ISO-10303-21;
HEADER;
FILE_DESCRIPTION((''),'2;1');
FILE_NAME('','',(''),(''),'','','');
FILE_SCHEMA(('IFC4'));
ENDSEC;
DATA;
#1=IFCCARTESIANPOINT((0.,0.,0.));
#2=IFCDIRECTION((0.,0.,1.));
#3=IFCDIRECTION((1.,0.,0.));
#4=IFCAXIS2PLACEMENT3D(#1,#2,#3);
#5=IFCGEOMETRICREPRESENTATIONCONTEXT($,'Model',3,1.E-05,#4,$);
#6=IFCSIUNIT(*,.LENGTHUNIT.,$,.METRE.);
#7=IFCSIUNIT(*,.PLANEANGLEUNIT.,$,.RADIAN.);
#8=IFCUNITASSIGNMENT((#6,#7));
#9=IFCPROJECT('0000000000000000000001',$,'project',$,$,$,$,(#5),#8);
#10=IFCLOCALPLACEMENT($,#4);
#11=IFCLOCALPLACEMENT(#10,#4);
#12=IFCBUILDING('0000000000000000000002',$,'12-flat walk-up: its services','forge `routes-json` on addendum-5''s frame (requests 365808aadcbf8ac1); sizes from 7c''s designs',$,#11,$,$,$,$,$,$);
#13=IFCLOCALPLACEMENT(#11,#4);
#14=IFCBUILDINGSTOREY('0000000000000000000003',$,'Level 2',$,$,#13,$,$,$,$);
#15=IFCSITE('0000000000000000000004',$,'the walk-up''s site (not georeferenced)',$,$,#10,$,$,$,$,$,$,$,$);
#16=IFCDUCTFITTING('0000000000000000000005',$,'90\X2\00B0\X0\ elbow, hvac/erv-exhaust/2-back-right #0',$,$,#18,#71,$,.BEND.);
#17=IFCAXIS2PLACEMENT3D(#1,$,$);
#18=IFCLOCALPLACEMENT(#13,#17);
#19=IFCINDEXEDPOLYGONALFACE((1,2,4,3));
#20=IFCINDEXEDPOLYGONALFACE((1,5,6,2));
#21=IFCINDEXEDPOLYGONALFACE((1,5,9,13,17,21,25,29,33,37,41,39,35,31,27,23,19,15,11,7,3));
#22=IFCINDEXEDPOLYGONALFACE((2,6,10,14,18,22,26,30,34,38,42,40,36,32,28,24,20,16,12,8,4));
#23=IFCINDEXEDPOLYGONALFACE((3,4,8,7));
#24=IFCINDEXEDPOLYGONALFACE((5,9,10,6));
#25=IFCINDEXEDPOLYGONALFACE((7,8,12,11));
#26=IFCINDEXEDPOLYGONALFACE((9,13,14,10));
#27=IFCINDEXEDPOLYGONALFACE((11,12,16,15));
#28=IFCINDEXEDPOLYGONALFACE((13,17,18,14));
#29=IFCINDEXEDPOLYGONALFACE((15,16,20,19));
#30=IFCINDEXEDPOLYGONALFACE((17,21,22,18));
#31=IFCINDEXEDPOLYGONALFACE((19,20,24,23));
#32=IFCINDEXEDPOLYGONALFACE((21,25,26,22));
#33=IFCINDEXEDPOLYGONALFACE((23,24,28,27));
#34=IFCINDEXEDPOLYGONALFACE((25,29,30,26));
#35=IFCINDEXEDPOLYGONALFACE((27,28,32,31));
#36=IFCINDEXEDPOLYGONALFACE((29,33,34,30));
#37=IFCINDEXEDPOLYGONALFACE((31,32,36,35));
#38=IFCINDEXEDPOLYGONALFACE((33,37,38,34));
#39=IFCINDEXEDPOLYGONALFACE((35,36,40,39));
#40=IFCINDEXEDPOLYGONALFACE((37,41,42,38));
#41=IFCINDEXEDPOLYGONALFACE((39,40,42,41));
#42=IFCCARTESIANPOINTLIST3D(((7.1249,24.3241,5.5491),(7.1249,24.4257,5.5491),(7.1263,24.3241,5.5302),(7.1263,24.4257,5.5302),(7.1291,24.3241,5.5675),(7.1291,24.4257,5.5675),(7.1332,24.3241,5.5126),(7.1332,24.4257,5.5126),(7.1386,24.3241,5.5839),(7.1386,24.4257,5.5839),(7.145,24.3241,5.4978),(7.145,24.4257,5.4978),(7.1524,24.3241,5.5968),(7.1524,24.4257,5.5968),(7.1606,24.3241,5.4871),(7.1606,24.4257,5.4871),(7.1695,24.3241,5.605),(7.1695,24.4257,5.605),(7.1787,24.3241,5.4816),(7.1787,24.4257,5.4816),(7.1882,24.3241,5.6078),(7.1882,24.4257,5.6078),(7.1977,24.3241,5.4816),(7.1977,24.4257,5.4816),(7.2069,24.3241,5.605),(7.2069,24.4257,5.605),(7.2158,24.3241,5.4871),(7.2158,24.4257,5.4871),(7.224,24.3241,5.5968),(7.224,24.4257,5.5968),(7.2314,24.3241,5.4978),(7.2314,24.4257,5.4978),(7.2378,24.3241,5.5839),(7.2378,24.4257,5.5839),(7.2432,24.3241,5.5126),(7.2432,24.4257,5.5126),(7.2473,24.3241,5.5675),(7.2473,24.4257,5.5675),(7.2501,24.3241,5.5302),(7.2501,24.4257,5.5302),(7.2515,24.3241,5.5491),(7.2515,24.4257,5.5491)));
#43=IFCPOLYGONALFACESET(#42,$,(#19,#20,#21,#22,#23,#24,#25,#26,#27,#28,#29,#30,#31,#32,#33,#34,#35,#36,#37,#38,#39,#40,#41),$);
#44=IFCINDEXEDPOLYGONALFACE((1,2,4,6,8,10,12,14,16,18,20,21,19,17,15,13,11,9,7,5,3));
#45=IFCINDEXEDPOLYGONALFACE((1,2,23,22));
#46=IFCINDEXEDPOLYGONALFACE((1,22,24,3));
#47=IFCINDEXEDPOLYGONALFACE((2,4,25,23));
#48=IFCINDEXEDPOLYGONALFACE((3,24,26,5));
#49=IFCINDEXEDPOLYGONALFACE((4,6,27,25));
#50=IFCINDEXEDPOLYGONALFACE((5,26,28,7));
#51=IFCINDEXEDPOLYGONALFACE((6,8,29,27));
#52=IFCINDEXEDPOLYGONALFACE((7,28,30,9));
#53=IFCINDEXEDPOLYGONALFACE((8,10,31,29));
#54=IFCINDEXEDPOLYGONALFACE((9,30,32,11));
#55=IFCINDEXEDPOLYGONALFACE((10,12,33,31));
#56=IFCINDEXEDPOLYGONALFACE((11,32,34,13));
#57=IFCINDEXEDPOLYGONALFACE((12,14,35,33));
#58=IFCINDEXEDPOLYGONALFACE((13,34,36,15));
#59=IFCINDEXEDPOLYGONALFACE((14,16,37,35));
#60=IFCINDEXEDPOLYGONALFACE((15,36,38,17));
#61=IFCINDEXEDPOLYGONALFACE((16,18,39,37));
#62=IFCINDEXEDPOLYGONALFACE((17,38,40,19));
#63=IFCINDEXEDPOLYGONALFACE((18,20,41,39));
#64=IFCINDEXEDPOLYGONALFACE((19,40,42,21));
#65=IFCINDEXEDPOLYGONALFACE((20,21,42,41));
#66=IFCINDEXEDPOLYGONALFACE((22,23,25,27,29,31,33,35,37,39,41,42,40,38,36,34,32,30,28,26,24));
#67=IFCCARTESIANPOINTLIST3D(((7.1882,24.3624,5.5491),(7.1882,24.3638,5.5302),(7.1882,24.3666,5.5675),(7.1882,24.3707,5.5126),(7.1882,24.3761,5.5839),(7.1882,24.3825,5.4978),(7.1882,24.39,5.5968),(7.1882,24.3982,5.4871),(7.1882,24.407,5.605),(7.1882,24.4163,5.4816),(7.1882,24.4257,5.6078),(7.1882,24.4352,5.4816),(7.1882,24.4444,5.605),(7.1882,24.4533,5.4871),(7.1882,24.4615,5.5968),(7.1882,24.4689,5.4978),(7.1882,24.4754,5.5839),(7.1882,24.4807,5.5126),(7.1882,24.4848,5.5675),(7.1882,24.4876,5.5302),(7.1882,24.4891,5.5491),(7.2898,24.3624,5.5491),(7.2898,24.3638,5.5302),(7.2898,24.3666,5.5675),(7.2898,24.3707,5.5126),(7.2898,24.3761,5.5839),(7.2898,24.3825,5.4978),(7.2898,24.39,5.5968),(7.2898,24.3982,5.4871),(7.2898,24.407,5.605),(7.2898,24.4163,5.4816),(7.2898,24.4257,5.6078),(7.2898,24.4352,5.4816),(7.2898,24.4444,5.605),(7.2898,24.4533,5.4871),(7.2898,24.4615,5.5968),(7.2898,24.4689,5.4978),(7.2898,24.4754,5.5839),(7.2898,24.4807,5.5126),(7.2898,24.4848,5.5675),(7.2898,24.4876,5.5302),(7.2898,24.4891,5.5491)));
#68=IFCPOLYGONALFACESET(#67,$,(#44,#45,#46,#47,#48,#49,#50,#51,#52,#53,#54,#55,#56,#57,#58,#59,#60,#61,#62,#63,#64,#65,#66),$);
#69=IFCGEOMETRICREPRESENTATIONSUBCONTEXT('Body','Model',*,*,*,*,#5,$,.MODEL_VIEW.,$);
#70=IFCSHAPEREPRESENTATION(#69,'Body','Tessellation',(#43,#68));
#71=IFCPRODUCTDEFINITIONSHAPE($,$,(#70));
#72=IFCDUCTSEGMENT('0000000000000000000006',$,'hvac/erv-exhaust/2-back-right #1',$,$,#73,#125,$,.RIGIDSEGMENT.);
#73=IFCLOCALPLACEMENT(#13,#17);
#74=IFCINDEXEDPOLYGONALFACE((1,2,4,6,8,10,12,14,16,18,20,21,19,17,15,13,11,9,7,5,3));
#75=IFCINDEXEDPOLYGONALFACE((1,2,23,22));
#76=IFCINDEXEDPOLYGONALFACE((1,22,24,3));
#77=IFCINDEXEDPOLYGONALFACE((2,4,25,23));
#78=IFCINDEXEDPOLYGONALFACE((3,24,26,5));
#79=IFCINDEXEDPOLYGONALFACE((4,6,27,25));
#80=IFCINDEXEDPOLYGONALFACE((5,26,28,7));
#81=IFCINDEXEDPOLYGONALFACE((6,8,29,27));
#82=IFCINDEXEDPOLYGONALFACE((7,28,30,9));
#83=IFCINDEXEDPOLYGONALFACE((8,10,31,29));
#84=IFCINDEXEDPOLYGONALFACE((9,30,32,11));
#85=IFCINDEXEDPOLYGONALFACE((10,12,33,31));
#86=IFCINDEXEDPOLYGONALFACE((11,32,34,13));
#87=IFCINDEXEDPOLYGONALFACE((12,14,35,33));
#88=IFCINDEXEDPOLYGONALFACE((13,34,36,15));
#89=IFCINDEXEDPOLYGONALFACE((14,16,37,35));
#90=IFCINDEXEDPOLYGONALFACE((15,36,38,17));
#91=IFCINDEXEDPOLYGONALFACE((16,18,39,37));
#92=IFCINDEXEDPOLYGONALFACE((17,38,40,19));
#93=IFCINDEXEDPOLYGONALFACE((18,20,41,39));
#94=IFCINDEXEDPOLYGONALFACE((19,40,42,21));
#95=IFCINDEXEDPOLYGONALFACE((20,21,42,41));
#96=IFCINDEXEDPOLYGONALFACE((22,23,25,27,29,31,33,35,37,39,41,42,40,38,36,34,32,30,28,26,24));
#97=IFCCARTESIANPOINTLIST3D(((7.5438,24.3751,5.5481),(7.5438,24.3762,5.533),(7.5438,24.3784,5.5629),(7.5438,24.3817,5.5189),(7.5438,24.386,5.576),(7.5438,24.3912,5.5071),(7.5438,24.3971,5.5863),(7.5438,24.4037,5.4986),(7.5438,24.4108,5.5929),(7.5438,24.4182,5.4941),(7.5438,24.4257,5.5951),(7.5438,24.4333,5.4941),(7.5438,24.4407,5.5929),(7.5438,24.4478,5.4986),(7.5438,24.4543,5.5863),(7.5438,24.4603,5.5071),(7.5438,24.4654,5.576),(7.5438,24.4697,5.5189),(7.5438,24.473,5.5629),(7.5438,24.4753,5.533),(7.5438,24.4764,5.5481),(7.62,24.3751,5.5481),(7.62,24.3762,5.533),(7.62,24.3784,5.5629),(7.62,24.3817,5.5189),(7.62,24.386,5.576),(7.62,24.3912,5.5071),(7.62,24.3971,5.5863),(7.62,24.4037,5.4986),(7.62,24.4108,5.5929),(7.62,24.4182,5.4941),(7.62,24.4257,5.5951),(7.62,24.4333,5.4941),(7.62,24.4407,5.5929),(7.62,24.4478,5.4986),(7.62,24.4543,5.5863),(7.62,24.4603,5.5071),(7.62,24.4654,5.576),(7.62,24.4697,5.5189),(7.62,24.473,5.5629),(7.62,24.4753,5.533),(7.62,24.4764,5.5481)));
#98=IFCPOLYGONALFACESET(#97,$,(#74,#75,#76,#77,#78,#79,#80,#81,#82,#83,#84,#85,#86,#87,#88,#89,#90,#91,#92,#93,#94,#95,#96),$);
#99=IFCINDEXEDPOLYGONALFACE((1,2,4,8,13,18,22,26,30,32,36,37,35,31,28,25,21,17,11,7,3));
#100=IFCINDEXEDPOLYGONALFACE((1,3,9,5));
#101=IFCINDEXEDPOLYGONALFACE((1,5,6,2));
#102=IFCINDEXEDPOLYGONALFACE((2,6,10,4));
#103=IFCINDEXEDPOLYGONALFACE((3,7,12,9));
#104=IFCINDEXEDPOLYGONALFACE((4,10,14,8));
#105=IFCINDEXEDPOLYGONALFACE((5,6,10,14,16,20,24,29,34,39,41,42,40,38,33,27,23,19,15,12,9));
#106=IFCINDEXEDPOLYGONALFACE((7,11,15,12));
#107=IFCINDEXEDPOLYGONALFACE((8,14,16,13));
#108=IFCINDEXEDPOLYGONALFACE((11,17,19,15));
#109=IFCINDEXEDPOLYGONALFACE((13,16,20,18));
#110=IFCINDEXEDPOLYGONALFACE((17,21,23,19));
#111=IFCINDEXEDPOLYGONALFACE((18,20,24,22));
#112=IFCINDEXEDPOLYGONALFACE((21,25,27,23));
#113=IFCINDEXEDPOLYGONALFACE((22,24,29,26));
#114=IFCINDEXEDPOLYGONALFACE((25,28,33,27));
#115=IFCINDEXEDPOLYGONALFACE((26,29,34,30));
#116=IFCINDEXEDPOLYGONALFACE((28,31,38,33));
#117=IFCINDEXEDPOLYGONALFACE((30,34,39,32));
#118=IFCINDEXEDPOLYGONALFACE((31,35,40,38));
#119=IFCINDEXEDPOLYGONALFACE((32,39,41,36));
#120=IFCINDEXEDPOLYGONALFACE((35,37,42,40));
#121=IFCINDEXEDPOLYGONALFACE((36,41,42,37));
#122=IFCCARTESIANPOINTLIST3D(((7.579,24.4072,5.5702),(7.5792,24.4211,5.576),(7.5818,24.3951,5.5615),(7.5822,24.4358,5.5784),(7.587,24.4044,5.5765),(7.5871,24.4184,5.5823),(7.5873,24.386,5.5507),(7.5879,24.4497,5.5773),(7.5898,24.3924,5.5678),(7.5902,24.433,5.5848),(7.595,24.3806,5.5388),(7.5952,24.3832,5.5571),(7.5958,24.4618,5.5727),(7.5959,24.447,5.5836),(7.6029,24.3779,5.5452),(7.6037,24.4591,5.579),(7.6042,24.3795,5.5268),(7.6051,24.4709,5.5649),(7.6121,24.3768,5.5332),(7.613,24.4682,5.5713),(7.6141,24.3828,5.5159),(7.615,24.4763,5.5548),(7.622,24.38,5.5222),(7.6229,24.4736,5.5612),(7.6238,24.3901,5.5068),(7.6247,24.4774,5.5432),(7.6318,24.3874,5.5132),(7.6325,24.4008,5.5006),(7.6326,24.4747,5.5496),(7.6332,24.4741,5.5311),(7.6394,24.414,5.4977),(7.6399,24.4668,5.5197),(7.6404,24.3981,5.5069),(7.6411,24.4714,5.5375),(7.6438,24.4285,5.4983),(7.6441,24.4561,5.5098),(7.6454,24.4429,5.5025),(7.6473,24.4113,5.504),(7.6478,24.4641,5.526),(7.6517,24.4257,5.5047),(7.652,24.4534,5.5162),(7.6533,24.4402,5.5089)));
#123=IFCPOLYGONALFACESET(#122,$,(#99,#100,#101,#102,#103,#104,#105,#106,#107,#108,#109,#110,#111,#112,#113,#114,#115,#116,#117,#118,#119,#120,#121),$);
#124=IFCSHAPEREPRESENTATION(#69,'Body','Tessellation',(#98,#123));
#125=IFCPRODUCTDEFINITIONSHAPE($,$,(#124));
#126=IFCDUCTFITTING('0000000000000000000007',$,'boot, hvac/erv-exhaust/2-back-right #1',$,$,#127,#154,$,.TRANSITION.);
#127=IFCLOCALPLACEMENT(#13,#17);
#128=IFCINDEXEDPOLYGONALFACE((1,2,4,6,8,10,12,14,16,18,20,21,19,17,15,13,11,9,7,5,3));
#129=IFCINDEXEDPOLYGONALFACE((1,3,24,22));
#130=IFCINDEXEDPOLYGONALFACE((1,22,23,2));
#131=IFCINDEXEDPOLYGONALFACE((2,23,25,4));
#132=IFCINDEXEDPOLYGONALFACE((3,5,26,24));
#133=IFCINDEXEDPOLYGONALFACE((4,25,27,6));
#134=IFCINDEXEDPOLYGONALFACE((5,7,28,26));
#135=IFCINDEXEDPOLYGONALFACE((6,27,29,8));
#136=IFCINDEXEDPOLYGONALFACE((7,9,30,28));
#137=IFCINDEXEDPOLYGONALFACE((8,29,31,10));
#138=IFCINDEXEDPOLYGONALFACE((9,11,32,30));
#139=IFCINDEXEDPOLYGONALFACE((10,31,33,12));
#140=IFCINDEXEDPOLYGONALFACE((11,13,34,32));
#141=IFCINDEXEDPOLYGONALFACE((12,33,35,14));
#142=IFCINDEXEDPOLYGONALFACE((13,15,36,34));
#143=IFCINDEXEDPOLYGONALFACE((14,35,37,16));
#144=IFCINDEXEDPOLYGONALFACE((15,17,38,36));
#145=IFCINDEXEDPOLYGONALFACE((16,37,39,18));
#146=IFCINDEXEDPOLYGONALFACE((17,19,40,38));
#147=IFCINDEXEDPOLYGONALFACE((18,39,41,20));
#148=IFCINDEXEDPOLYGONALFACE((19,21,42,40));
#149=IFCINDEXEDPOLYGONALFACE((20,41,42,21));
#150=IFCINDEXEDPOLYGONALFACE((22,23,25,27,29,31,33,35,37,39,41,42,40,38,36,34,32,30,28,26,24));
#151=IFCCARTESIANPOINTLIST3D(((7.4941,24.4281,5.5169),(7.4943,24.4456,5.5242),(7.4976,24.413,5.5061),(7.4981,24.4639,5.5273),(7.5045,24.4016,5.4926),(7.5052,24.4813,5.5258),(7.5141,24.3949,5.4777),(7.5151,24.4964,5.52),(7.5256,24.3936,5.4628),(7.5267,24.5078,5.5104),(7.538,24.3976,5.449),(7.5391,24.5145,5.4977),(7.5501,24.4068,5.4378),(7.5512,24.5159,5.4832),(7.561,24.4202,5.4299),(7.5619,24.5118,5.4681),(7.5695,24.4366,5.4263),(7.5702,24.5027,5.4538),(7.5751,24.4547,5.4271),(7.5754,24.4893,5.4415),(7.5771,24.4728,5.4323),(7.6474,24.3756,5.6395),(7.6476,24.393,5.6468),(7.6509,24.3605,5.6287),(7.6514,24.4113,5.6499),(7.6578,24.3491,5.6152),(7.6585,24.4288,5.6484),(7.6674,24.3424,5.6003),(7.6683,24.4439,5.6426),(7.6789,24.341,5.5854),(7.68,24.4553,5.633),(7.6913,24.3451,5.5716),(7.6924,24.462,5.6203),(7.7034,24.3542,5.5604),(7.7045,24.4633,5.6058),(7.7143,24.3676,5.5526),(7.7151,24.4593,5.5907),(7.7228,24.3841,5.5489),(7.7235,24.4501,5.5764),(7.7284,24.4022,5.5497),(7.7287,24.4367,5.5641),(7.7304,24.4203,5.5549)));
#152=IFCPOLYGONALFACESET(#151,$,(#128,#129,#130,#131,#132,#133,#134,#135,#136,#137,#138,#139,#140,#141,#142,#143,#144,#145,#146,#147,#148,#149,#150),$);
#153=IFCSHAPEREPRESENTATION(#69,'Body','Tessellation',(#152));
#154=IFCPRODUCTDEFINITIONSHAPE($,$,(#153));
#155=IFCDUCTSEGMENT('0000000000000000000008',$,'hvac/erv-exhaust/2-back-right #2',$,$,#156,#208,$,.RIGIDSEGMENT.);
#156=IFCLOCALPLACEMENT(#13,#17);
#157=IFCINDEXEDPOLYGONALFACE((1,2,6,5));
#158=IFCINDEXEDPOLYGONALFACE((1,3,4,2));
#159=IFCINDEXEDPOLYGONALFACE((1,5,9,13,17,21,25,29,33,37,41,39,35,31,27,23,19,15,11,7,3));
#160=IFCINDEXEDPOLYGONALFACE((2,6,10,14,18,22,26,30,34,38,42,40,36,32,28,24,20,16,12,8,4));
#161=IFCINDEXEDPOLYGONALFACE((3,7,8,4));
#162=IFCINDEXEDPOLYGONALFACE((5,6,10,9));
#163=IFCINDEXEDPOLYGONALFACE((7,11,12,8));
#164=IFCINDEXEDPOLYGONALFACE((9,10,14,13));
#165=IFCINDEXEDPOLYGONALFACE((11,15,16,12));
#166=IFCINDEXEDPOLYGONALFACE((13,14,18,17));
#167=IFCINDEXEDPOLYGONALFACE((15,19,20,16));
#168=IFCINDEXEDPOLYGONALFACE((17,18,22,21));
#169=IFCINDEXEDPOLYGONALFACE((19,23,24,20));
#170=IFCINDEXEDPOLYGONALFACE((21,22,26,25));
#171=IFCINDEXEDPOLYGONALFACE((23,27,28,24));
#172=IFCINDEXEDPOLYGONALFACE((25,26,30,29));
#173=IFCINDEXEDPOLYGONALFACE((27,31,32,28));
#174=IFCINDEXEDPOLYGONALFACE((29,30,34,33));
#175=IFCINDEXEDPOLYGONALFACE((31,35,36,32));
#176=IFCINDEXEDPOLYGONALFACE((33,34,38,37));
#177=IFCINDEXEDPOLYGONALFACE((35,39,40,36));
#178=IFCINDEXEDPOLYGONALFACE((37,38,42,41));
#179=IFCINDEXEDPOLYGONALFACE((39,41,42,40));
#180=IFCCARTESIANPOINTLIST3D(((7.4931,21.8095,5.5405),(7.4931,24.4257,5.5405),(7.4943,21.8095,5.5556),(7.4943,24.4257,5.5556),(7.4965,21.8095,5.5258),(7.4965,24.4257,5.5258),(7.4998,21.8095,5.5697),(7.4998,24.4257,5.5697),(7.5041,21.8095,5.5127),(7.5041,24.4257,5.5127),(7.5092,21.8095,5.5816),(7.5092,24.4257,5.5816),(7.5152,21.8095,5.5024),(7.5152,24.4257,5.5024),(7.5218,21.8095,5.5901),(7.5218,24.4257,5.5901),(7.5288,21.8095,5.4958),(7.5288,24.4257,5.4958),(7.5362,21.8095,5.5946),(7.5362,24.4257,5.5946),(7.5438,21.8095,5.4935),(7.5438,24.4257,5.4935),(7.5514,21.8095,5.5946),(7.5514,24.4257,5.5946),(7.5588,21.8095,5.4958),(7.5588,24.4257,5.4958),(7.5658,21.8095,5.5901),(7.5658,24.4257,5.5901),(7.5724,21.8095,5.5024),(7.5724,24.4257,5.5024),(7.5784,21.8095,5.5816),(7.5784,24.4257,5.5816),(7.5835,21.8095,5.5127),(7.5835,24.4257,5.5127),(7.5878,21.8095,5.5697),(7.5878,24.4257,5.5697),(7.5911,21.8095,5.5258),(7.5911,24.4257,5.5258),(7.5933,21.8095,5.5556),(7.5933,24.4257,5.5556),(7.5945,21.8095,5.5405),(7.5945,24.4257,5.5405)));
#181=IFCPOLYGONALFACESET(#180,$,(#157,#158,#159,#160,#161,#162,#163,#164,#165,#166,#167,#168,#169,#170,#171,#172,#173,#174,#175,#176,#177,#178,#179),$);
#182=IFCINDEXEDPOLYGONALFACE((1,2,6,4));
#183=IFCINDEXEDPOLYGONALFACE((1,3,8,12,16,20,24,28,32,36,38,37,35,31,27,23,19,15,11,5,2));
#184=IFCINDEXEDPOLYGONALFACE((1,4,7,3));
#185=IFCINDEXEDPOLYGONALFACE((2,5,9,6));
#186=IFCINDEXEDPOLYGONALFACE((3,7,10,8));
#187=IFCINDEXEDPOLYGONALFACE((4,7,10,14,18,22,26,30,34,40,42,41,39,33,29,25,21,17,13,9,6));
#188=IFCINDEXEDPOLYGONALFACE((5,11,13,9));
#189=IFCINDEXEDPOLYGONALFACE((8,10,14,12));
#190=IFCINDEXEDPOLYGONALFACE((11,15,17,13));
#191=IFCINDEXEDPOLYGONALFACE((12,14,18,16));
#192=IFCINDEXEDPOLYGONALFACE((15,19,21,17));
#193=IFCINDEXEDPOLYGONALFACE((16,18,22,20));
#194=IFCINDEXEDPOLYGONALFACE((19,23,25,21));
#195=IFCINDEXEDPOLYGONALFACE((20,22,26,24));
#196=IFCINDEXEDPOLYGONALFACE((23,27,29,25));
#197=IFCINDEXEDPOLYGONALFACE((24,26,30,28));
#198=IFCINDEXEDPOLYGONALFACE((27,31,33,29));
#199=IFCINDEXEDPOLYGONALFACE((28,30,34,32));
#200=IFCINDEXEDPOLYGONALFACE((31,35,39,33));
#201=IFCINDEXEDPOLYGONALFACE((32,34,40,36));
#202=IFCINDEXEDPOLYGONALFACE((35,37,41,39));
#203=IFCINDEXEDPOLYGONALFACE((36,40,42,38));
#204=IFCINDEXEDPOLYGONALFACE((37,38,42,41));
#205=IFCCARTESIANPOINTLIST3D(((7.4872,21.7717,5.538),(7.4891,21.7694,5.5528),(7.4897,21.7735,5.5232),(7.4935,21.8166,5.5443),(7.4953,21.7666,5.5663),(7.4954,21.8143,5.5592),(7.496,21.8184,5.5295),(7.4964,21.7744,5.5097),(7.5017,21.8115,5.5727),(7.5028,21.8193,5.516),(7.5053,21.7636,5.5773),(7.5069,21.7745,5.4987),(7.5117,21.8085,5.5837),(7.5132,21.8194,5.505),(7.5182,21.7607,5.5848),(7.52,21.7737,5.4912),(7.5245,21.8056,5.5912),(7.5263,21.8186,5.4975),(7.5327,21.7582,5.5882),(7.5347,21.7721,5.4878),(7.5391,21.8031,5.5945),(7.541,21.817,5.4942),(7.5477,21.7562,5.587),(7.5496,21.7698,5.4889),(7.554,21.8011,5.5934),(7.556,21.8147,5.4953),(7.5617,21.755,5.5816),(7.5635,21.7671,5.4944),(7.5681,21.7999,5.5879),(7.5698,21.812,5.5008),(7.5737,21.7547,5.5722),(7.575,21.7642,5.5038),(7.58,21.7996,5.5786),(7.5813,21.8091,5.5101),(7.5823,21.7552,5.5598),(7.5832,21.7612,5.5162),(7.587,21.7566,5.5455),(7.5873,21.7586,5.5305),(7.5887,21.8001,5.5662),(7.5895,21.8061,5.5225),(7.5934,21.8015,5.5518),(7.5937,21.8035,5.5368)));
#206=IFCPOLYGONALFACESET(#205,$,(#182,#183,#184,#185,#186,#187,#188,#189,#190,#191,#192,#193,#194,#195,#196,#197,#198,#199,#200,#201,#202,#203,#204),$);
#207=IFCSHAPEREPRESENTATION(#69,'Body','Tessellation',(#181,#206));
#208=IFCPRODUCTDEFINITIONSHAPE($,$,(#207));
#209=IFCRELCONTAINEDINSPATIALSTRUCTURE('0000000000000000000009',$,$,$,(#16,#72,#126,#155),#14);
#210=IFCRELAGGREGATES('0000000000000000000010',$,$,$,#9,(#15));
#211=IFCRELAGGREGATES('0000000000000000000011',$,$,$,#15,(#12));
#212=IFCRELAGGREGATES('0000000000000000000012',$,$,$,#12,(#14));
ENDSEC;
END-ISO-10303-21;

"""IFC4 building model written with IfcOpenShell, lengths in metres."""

from ifc_helpers import new_model, entity, si_unit, frame, origin_with_axes, place, context, subcontext, project, spatial, element, save


model = new_model("IFC4")

# Units and contexts
model_context = context("Model", 3, precision=1e-05, world=origin_with_axes())
body_context = subcontext(model_context, "Body", "Model", "MODEL_VIEW")
ifc_project = project(units=[si_unit("LENGTHUNIT", "METRE"), si_unit("PLANEANGLEUNIT", "RADIAN")], contexts=[model_context])

# Site, building, storey
site_placement = place(None, origin_with_axes())
site = spatial("IfcSite", under=ifc_project, at=site_placement, Name="the walk-up's site (not georeferenced)")
building_placement = place(site_placement, origin_with_axes())
building = spatial("IfcBuilding", under=site, at=building_placement, Name="12-flat walk-up: its services", Description="forge `routes-json` on addendum-5's frame (requests 365808aadcbf8ac1); sizes from 7c's designs")
storey_placement = place(building_placement, origin_with_axes())
storey = spatial("IfcBuildingStorey", under=building, at=storey_placement, Name="Level 2")

# Duct fitting
duct_fitting_1_placement = place(storey_placement, frame((7.1882, 24.3241, 5.5443), z_axis=(0.0, 0.0, 1.0), x_axis=(1.0, 0.0, 0.0)))
element("IfcDuctFitting", 1, at=duct_fitting_1_placement, inside=storey, Name="90° elbow, hvac/erv-exhaust/2-back-right #0", PredefinedType="BEND", context=body_context, shape_type="AdvancedSweptSolid", body=[
    entity("IfcSweptDiskSolid", entity("IfcPolyline", [entity("IfcCartesianPoint", [0.0, 0.0, 0.0]), entity("IfcCartesianPoint", [0.0, 0.1016, 0.0])]), 0.0635),
    entity("IfcSweptDiskSolid", entity("IfcPolyline", [entity("IfcCartesianPoint", [0.0, 0.1016, 0.0]), entity("IfcCartesianPoint", [0.1016, 0.1016, 0.0])]), 0.0635),
])

# Duct segment
duct_segment_1_placement = place(storey_placement, frame((7.5438, 24.4257, 5.5443), z_axis=(0.0, 0.0, 1.0), x_axis=(1.0, 0.0, 0.0)))
element("IfcDuctSegment", 2, at=duct_segment_1_placement, inside=storey, Name="hvac/erv-exhaust/2-back-right #1", PredefinedType="RIGIDSEGMENT", context=body_context, shape_type="AdvancedSweptSolid", body=[
    entity("IfcSweptDiskSolid", entity("IfcPolyline", [entity("IfcCartesianPoint", [0.0, 0.0, 0.0]), entity("IfcCartesianPoint", [0.0762, 0.0, 0.0])]), 0.0508),
    entity("IfcSweptDiskSolid", entity("IfcPolyline", [entity("IfcCartesianPoint", [0.0762, 0.0, 0.0]), entity("IfcCartesianPoint", [0.0683, 0.0027, -0.0063])]), 0.0508),
])

# Duct fitting
duct_fitting_2_placement = place(storey_placement, frame((7.6887, 24.4022, 5.5993), z_axis=(0.0, 0.0, 1.0), x_axis=(1.0, 0.0, 0.0)))
element("IfcDuctFitting", 3, at=duct_fitting_2_placement, inside=storey, Name="boot, hvac/erv-exhaust/2-back-right #1", PredefinedType="TRANSITION", context=body_context, shape_type="AdvancedSweptSolid", body=[
    entity("IfcSweptDiskSolid", entity("IfcPolyline", [entity("IfcCartesianPoint", [0.0, 0.0, 0.0]), entity("IfcCartesianPoint", [-0.1533, 0.0526, -0.1226])]), 0.0635),
])

# Duct segment
duct_segment_2_placement = place(storey_placement, frame((7.5438, 24.4257, 5.5443), z_axis=(0.0, 0.0, 1.0), x_axis=(1.0, 0.0, 0.0)))
element("IfcDuctSegment", 4, at=duct_segment_2_placement, inside=storey, Name="hvac/erv-exhaust/2-back-right #2", PredefinedType="RIGIDSEGMENT", context=body_context, shape_type="AdvancedSweptSolid", body=[
    entity("IfcSweptDiskSolid", entity("IfcPolyline", [entity("IfcCartesianPoint", [0.0, 0.0, 0.0]), entity("IfcCartesianPoint", [0.0, -2.6162, 0.0])]), 0.0508),
    entity("IfcSweptDiskSolid", entity("IfcPolyline", [entity("IfcCartesianPoint", [0.0, -2.6162, 0.0]), entity("IfcCartesianPoint", [-0.0063, -2.6611, -0.0063])]), 0.0508),
])

save(model, "model.ifc")
